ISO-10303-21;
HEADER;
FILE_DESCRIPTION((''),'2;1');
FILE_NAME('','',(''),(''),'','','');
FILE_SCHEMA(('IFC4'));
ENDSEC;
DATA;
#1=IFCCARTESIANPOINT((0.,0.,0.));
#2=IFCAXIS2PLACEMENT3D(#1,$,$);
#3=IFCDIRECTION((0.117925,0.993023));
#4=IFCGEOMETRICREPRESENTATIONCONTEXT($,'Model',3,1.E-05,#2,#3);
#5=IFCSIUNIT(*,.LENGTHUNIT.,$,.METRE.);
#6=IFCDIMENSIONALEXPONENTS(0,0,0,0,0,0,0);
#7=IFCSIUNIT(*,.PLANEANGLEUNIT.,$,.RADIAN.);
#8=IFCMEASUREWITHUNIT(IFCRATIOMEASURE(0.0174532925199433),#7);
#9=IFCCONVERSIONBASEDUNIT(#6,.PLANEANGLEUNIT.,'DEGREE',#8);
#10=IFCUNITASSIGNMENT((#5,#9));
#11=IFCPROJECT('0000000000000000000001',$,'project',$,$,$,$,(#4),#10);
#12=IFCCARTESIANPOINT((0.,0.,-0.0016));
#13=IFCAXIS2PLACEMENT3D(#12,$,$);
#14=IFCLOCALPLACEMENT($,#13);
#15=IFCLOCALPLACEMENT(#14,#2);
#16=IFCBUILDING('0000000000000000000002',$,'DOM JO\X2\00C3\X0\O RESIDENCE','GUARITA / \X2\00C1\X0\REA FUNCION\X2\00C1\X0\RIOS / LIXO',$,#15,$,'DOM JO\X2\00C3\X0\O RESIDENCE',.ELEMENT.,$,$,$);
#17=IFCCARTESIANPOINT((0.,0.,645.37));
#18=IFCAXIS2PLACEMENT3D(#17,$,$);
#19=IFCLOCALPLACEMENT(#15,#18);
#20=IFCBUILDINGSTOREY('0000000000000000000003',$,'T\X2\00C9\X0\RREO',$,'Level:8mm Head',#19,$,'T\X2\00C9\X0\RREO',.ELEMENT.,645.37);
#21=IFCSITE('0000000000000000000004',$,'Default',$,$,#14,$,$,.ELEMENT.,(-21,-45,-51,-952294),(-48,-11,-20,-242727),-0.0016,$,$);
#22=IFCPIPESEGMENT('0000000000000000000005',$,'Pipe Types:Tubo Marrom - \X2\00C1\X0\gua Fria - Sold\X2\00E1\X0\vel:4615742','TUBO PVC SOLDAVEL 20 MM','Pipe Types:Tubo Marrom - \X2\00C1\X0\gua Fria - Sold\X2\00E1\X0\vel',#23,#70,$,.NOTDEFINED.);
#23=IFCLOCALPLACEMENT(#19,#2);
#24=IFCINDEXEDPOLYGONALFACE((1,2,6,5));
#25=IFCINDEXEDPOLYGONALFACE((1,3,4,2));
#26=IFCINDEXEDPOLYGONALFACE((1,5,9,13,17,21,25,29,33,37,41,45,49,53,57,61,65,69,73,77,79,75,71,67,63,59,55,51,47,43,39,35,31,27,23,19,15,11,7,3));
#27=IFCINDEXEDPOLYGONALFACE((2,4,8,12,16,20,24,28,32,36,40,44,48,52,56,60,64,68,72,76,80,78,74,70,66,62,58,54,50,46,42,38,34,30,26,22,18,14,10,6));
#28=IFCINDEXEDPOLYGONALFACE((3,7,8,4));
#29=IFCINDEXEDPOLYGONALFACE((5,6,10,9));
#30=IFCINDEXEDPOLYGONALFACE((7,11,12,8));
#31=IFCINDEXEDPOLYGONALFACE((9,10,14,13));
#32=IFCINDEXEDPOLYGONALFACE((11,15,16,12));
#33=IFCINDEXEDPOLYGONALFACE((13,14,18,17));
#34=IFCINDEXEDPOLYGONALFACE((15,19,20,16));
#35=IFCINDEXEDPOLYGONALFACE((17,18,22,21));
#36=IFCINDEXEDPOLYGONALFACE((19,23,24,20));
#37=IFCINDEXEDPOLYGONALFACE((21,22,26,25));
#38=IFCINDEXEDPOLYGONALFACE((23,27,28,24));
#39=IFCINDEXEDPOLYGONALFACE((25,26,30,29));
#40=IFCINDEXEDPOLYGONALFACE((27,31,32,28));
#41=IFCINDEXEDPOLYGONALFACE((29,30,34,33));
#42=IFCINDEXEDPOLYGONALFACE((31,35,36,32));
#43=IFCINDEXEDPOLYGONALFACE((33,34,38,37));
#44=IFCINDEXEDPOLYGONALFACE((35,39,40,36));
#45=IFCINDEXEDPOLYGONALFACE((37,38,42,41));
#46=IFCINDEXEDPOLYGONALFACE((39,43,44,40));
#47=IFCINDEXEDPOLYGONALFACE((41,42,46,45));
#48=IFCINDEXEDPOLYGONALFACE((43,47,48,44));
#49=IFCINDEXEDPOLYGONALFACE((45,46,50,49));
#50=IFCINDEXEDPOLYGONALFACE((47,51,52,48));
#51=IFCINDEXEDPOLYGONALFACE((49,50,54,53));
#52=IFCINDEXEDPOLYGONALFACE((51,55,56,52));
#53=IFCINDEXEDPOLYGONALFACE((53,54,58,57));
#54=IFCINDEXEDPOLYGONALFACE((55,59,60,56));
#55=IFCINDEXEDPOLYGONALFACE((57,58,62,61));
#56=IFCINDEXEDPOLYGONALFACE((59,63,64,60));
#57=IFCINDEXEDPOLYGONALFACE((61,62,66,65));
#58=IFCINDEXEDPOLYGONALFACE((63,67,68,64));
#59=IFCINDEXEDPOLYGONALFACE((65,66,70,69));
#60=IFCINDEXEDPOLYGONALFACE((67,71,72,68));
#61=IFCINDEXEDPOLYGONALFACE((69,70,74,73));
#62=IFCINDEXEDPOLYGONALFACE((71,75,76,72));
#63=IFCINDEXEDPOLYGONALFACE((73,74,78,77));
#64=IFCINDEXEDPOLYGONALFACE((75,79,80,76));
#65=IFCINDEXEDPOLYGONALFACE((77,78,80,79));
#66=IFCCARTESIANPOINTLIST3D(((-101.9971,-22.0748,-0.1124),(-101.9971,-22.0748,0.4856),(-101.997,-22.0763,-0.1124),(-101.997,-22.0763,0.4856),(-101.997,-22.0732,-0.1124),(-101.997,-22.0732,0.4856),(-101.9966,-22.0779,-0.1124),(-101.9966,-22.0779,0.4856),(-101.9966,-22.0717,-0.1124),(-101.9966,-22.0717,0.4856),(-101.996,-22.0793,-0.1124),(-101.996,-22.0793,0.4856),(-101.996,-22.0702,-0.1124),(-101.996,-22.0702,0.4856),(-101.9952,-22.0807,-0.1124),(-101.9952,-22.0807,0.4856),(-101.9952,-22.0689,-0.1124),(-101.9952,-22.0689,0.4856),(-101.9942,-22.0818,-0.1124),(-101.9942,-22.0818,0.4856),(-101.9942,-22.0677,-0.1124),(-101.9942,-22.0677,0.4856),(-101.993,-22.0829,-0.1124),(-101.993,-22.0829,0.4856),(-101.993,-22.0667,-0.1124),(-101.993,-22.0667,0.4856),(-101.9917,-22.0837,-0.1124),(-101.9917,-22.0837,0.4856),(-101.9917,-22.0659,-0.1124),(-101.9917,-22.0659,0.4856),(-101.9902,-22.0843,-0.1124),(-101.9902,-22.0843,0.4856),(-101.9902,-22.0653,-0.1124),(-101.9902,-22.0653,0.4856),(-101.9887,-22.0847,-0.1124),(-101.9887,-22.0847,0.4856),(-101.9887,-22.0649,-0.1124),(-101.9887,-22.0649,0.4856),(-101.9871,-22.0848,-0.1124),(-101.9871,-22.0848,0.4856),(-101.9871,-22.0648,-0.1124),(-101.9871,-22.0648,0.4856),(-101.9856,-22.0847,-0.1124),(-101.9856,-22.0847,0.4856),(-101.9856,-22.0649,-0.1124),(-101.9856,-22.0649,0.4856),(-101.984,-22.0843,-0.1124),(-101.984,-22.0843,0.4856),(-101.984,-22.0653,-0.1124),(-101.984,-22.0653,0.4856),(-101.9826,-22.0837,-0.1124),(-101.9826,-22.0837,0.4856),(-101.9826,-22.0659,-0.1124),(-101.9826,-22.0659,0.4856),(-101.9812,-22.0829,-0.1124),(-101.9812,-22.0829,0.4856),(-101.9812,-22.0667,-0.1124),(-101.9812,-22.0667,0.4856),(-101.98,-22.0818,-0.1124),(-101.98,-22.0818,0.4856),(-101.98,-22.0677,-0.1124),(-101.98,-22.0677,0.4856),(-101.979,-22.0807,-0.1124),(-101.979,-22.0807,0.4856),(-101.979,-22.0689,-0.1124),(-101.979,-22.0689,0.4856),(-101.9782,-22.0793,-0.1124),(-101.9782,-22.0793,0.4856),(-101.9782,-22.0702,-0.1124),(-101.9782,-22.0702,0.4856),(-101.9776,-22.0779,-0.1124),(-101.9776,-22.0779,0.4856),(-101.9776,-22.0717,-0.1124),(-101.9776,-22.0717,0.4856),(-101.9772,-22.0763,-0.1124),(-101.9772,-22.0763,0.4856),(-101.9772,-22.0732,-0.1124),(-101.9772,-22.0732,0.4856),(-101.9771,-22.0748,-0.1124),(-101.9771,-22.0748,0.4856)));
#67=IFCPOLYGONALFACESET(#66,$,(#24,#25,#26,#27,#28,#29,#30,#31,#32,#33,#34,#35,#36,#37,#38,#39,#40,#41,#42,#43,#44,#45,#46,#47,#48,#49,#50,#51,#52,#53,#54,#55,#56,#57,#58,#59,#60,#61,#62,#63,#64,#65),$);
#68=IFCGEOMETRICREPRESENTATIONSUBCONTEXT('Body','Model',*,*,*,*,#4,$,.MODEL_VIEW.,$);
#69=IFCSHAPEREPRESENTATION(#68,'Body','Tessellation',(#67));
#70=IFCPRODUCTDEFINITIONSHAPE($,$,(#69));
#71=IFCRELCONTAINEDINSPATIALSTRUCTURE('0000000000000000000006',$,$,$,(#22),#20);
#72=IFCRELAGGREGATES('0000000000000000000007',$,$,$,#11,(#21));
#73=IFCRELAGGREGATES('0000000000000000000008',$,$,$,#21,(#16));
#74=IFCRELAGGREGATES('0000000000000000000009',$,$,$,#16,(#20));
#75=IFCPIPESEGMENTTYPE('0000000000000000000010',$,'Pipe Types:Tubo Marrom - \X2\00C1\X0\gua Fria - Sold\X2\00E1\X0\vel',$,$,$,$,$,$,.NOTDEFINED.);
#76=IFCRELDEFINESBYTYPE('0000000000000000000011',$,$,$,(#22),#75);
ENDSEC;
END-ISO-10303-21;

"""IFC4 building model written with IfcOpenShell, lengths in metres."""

from ifc_helpers import new_model, entity, si_unit, converted_unit, direction, frame, origin, place, context, subcontext, project, spatial, indexed_curve, outline, extrude, type_object, element, save


model = new_model("IFC4")

# Units and contexts
model_context = context("Model", 3, precision=1e-05, world=origin(), true_north=direction((0.117925, 0.993023)))
body_context = subcontext(model_context, "Body", "Model", "MODEL_VIEW")
ifc_project = project(units=[si_unit("LENGTHUNIT", "METRE"), converted_unit("PLANEANGLEUNIT", "DEGREE", entity("IfcRatioMeasure", 0.0174532925199433), si_unit("PLANEANGLEUNIT", "RADIAN"), dimensions=[0, 0, 0, 0, 0, 0, 0])], contexts=[model_context])

# Site, building, storey
site_placement = place(None, frame((0.0, 0.0, -0.0016)))
site = spatial("IfcSite", under=ifc_project, at=site_placement, Name="Default", CompositionType="ELEMENT", RefLatitude=(-21, -45, -51, -952294), RefLongitude=(-48, -11, -20, -242727), RefElevation=-0.0016)
building_placement = place(site_placement, origin())
building = spatial("IfcBuilding", under=site, at=building_placement, Name="DOM JOÃO RESIDENCE", Description="GUARITA / ÁREA FUNCIONÁRIOS / LIXO", LongName="DOM JOÃO RESIDENCE", CompositionType="ELEMENT")
storey_placement = place(building_placement, frame((0.0, 0.0, 645.37)))
storey = spatial("IfcBuildingStorey", under=building, at=storey_placement, Name="TÉRREO", ObjectType="Level:8mm Head", LongName="TÉRREO", CompositionType="ELEMENT", Elevation=645.37)

# Pipe segment
pipe_segment_type_1 = type_object("IfcPipeSegmentType", Name="Pipe Types:Tubo Marrom - Água Fria - Soldável", PredefinedType="NOTDEFINED")
pipe_segment_1_placement = place(storey_placement, frame((-101.9987, -22.0864, -0.1124)))
element("IfcPipeSegment", 1, at=pipe_segment_1_placement, inside=storey, type_object=pipe_segment_type_1, Name="Pipe Types:Tubo Marrom - Água Fria - Soldável:4615742", Description="TUBO PVC SOLDAVEL 20 MM", ObjectType="Pipe Types:Tubo Marrom - Água Fria - Soldável", PredefinedType="NOTDEFINED", context=body_context, shape_type="SweptSolid", body=[
    extrude(outline(indexed_curve([(0.01, 0.0), (0.0099, 0.0016), (0.0095, 0.0031), (0.0089, 0.0045), (0.0081, 0.0059), (0.0071, 0.0071), (0.0059, 0.0081), (0.0045, 0.0089), (0.0031, 0.0095), (0.0016, 0.0099), (0.0, 0.01), (-0.0016, 0.0099), (-0.0031, 0.0095), (-0.0045, 0.0089), (-0.0059, 0.0081), (-0.0071, 0.0071), (-0.0081, 0.0059), (-0.0089, 0.0045), (-0.0095, 0.0031), (-0.0099, 0.0016), (-0.01, 0.0), (-0.0099, -0.0016), (-0.0095, -0.0031), (-0.0089, -0.0045), (-0.0081, -0.0059), (-0.0071, -0.0071), (-0.0059, -0.0081), (-0.0045, -0.0089), (-0.0031, -0.0095), (-0.0016, -0.0099), (0.0, -0.01), (0.0016, -0.0099), (0.0031, -0.0095), (0.0045, -0.0089), (0.0059, -0.0081), (0.0071, -0.0071), (0.0081, -0.0059), (0.0089, -0.0045), (0.0095, -0.0031), (0.0099, -0.0016), (0.01, 0.0)], self_intersect=False)), frame((0.0116, 0.0116, 0.0)), (0.0, 0.0, 1.0), 0.598),
])

save(model, "model.ifc")
